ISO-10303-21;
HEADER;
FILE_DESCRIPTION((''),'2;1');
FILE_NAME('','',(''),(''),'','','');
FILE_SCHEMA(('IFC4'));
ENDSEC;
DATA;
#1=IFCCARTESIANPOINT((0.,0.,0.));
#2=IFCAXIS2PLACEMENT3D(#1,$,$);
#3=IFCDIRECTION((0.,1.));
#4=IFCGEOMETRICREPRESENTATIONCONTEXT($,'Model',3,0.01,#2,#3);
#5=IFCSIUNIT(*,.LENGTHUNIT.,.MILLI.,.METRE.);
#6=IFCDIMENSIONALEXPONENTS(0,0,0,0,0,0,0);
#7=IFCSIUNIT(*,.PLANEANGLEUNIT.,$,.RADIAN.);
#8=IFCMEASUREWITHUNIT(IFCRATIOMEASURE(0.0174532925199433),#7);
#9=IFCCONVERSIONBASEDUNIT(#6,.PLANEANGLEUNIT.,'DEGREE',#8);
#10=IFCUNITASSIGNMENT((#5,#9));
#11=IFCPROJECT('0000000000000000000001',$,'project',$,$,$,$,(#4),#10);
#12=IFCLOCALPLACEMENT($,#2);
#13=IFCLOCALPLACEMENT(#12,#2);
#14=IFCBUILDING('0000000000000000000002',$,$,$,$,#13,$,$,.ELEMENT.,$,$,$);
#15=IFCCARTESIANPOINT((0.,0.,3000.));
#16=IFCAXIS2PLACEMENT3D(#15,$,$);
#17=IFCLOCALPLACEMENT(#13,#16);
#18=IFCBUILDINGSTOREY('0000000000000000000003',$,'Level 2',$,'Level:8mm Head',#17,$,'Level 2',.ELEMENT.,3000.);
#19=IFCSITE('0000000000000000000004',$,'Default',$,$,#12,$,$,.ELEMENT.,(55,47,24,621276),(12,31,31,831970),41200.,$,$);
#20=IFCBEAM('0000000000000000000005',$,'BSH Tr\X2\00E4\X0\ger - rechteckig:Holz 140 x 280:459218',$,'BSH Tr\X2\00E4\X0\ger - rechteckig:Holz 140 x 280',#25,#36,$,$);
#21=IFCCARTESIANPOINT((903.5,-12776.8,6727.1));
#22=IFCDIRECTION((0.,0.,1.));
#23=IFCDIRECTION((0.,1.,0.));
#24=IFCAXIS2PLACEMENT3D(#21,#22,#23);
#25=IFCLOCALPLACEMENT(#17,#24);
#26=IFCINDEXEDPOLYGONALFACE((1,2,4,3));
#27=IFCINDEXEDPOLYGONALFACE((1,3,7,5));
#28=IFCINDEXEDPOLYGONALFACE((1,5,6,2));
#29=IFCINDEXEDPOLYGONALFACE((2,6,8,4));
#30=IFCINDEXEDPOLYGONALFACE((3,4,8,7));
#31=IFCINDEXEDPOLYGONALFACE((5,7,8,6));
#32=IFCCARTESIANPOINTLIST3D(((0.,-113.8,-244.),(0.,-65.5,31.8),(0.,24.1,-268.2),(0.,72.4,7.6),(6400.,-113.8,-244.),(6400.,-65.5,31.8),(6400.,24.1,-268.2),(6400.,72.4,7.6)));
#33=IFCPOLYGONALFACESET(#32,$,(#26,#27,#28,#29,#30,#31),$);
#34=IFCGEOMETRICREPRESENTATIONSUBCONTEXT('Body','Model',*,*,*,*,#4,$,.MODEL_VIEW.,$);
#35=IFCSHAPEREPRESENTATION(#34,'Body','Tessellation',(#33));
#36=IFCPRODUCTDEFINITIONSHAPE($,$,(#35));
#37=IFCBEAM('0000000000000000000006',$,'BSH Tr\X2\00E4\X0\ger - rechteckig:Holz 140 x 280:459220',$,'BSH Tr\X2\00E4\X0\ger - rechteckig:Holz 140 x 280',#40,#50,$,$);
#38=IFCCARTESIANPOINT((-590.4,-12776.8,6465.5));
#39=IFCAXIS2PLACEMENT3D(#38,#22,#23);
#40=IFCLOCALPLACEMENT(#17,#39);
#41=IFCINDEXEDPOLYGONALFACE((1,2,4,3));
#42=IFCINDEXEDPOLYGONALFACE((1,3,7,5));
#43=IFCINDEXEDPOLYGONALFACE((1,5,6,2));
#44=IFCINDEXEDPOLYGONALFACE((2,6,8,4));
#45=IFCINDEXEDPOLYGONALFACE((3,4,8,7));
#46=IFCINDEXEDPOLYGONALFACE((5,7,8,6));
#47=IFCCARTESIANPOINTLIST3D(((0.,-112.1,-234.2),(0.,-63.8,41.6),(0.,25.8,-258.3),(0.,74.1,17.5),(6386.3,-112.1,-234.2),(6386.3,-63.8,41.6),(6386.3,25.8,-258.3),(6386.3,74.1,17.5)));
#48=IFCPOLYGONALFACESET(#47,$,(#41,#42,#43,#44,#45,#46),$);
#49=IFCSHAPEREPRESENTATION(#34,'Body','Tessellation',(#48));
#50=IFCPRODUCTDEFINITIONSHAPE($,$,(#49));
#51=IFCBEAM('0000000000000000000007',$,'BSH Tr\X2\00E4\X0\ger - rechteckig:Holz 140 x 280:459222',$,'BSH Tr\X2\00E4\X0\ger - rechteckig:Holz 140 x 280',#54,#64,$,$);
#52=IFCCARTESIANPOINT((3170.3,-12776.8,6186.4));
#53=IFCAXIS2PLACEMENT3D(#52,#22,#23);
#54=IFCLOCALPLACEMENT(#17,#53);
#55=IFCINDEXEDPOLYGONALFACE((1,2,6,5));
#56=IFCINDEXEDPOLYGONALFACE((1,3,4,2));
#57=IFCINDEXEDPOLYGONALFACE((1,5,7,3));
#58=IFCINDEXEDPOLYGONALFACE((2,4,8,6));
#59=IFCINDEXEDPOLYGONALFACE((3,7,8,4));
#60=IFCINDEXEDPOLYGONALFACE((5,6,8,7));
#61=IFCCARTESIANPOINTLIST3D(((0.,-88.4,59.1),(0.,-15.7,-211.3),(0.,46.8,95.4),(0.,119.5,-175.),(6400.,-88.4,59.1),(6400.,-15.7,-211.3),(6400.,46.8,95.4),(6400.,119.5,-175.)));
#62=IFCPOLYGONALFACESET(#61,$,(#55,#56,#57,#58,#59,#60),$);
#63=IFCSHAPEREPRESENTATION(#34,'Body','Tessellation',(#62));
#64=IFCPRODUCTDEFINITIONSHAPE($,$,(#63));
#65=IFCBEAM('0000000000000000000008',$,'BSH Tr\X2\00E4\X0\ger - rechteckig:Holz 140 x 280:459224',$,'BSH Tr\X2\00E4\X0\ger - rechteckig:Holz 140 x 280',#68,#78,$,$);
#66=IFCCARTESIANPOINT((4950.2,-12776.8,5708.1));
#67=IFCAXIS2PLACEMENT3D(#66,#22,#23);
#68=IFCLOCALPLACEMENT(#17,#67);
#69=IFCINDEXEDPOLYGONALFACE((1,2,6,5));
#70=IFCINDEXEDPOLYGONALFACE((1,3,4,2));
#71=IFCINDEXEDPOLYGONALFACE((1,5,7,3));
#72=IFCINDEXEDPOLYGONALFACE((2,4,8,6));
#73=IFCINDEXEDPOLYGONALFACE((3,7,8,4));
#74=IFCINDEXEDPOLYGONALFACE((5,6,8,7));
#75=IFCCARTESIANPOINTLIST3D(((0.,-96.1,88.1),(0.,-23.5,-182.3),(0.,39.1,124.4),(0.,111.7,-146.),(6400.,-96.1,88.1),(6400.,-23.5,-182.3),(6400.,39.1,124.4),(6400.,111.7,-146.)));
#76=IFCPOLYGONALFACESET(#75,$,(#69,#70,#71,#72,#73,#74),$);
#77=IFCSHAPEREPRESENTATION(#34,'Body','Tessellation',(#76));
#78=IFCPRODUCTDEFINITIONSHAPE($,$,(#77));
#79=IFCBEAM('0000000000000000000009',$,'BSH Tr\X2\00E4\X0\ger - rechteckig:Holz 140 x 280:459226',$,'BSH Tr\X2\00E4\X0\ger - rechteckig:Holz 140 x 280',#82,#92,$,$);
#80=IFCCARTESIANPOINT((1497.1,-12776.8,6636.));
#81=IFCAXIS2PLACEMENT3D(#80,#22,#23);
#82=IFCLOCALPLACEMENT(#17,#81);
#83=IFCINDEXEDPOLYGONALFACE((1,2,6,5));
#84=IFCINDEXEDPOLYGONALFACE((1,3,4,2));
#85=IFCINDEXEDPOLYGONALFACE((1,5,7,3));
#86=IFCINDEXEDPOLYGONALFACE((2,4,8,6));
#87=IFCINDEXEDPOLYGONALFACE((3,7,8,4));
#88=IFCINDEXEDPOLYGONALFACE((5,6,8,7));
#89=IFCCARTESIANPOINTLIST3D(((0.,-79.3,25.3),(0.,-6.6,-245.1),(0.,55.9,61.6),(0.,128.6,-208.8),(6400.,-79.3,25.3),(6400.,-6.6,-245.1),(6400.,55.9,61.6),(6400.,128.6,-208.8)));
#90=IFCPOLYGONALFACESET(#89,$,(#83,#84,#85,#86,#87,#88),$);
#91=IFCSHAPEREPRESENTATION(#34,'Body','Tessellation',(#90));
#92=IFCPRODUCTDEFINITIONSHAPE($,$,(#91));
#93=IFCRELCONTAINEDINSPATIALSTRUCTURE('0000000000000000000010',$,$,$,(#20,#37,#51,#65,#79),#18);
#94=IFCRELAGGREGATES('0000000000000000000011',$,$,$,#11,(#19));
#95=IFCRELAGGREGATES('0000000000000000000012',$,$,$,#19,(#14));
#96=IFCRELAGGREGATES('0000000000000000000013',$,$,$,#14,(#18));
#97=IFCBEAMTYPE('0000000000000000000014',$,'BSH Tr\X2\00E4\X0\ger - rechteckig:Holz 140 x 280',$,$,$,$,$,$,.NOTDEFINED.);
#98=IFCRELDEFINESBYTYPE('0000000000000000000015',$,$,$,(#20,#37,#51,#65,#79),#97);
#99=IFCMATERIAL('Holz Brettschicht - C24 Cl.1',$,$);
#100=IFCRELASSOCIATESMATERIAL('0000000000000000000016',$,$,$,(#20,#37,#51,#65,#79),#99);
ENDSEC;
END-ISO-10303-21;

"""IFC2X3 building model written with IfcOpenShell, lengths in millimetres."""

from ifc_helpers import new_model, entity, si_unit, converted_unit, direction, frame, frame_2d, origin, place, context, subcontext, project, spatial, rectangle, extrude, material, type_object, element, save


model = new_model("IFC2X3")

# Units and contexts
model_context = context("Model", 3, precision=0.01, world=origin(), true_north=direction((0.0, 1.0)))
body_context = subcontext(model_context, "Body", "Model", "MODEL_VIEW")
ifc_project = project(units=[si_unit("LENGTHUNIT", "METRE", prefix="MILLI"), converted_unit("PLANEANGLEUNIT", "DEGREE", entity("IfcRatioMeasure", 0.0174532925199433), si_unit("PLANEANGLEUNIT", "RADIAN"), dimensions=[0, 0, 0, 0, 0, 0, 0])], contexts=[model_context])

# Site, building, storey
site_placement = place(None, origin())
site = spatial("IfcSite", under=ifc_project, at=site_placement, Name="Default", CompositionType="ELEMENT", RefLatitude=(55, 47, 24, 621276), RefLongitude=(12, 31, 31, 831970), RefElevation=41200.0)
building_placement = place(site_placement, origin())
building = spatial("IfcBuilding", under=site, at=building_placement, CompositionType="ELEMENT")
storey_placement = place(building_placement, frame((0.0, 0.0, 3000.0)))
storey = spatial("IfcBuildingStorey", under=building, at=storey_placement, Name="Level 2", ObjectType="Level:8mm Head", LongName="Level 2", CompositionType="ELEMENT", Elevation=3000.0)

# Beams
ifc_material = material(Name="Holz Brettschicht - C24 Cl.1")
beam_type_1 = type_object("IfcBeamType", Name="BSH Träger - rechteckig:Holz 140 x 280", PredefinedType="NOTDEFINED")
beam_1_placement = place(storey_placement, frame((903.5, -12776.8, 6727.1), z_axis=(0.0, 0.0, 1.0), x_axis=(0.0, 1.0, 0.0)))
element("IfcBeam", 1, at=beam_1_placement, inside=storey, type_object=beam_type_1, material=ifc_material, Name="BSH Träger - rechteckig:Holz 140 x 280:459218", ObjectType="BSH Träger - rechteckig:Holz 140 x 280", context=body_context, shape_type="SweptSolid", body=[
    extrude(rectangle(XDim=280.0, YDim=140.0, at=frame_2d((0.0, 0.0), x_axis=(1.0, 0.0))), frame((0.0, -20.7, -118.2), z_axis=(1.0, 0.0, 0.0), x_axis=(0.0, 0.172491, 0.985011)), (0.0, 0.0, 1.0), 6400.0),
])
beam_2_placement = place(storey_placement, frame((-590.4, -12776.8, 6465.5), z_axis=(0.0, 0.0, 1.0), x_axis=(0.0, 1.0, 0.0)))
element("IfcBeam", 2, at=beam_2_placement, inside=storey, type_object=beam_type_1, material=ifc_material, Name="BSH Träger - rechteckig:Holz 140 x 280:459220", ObjectType="BSH Träger - rechteckig:Holz 140 x 280", context=body_context, shape_type="SweptSolid", body=[
    extrude(rectangle(XDim=280.0, YDim=140.0, at=frame_2d((0.0, 0.0), x_axis=(1.0, 0.0))), frame((0.0, -19.0, -108.4), z_axis=(1.0, 0.0, 0.0), x_axis=(0.0, 0.172491, 0.985011)), (0.0, 0.0, 1.0), 6386.3),
])
beam_3_placement = place(storey_placement, frame((3170.3, -12776.8, 6186.4), z_axis=(0.0, 0.0, 1.0), x_axis=(0.0, 1.0, 0.0)))
element("IfcBeam", 3, at=beam_3_placement, inside=storey, type_object=beam_type_1, material=ifc_material, Name="BSH Träger - rechteckig:Holz 140 x 280:459222", ObjectType="BSH Träger - rechteckig:Holz 140 x 280", context=body_context, shape_type="SweptSolid", body=[
    extrude(rectangle(XDim=280.0, YDim=140.0, at=frame_2d((0.0, 0.0), x_axis=(1.0, 0.0))), frame((0.0, 15.6, -57.9), z_axis=(1.0, 0.0, 0.0), x_axis=(0.0, -0.259528, 0.965735)), (0.0, 0.0, 1.0), 6400.0),
])
beam_4_placement = place(storey_placement, frame((4950.2, -12776.8, 5708.1), z_axis=(0.0, 0.0, 1.0), x_axis=(0.0, 1.0, 0.0)))
element("IfcBeam", 4, at=beam_4_placement, inside=storey, type_object=beam_type_1, material=ifc_material, Name="BSH Träger - rechteckig:Holz 140 x 280:459224", ObjectType="BSH Träger - rechteckig:Holz 140 x 280", context=body_context, shape_type="SweptSolid", body=[
    extrude(rectangle(XDim=280.0, YDim=140.0, at=frame_2d((0.0, 0.0), x_axis=(1.0, 0.0))), frame((0.0, 7.8, -29.0), z_axis=(1.0, 0.0, 0.0), x_axis=(0.0, -0.259528, 0.965735)), (0.0, 0.0, 1.0), 6400.0),
])
beam_5_placement = place(storey_placement, frame((1497.1, -12776.8, 6636.0), z_axis=(0.0, 0.0, 1.0), x_axis=(0.0, 1.0, 0.0)))
element("IfcBeam", 5, at=beam_5_placement, inside=storey, type_object=beam_type_1, material=ifc_material, Name="BSH Träger - rechteckig:Holz 140 x 280:459226", ObjectType="BSH Träger - rechteckig:Holz 140 x 280", context=body_context, shape_type="SweptSolid", body=[
    extrude(rectangle(XDim=280.0, YDim=140.0, at=frame_2d((0.0, 0.0), x_axis=(1.0, 0.0))), frame((0.0, 24.7, -91.7), z_axis=(1.0, 0.0, 0.0), x_axis=(0.0, -0.259528, 0.965735)), (0.0, 0.0, 1.0), 6400.0),
])

save(model, "model.ifc")
